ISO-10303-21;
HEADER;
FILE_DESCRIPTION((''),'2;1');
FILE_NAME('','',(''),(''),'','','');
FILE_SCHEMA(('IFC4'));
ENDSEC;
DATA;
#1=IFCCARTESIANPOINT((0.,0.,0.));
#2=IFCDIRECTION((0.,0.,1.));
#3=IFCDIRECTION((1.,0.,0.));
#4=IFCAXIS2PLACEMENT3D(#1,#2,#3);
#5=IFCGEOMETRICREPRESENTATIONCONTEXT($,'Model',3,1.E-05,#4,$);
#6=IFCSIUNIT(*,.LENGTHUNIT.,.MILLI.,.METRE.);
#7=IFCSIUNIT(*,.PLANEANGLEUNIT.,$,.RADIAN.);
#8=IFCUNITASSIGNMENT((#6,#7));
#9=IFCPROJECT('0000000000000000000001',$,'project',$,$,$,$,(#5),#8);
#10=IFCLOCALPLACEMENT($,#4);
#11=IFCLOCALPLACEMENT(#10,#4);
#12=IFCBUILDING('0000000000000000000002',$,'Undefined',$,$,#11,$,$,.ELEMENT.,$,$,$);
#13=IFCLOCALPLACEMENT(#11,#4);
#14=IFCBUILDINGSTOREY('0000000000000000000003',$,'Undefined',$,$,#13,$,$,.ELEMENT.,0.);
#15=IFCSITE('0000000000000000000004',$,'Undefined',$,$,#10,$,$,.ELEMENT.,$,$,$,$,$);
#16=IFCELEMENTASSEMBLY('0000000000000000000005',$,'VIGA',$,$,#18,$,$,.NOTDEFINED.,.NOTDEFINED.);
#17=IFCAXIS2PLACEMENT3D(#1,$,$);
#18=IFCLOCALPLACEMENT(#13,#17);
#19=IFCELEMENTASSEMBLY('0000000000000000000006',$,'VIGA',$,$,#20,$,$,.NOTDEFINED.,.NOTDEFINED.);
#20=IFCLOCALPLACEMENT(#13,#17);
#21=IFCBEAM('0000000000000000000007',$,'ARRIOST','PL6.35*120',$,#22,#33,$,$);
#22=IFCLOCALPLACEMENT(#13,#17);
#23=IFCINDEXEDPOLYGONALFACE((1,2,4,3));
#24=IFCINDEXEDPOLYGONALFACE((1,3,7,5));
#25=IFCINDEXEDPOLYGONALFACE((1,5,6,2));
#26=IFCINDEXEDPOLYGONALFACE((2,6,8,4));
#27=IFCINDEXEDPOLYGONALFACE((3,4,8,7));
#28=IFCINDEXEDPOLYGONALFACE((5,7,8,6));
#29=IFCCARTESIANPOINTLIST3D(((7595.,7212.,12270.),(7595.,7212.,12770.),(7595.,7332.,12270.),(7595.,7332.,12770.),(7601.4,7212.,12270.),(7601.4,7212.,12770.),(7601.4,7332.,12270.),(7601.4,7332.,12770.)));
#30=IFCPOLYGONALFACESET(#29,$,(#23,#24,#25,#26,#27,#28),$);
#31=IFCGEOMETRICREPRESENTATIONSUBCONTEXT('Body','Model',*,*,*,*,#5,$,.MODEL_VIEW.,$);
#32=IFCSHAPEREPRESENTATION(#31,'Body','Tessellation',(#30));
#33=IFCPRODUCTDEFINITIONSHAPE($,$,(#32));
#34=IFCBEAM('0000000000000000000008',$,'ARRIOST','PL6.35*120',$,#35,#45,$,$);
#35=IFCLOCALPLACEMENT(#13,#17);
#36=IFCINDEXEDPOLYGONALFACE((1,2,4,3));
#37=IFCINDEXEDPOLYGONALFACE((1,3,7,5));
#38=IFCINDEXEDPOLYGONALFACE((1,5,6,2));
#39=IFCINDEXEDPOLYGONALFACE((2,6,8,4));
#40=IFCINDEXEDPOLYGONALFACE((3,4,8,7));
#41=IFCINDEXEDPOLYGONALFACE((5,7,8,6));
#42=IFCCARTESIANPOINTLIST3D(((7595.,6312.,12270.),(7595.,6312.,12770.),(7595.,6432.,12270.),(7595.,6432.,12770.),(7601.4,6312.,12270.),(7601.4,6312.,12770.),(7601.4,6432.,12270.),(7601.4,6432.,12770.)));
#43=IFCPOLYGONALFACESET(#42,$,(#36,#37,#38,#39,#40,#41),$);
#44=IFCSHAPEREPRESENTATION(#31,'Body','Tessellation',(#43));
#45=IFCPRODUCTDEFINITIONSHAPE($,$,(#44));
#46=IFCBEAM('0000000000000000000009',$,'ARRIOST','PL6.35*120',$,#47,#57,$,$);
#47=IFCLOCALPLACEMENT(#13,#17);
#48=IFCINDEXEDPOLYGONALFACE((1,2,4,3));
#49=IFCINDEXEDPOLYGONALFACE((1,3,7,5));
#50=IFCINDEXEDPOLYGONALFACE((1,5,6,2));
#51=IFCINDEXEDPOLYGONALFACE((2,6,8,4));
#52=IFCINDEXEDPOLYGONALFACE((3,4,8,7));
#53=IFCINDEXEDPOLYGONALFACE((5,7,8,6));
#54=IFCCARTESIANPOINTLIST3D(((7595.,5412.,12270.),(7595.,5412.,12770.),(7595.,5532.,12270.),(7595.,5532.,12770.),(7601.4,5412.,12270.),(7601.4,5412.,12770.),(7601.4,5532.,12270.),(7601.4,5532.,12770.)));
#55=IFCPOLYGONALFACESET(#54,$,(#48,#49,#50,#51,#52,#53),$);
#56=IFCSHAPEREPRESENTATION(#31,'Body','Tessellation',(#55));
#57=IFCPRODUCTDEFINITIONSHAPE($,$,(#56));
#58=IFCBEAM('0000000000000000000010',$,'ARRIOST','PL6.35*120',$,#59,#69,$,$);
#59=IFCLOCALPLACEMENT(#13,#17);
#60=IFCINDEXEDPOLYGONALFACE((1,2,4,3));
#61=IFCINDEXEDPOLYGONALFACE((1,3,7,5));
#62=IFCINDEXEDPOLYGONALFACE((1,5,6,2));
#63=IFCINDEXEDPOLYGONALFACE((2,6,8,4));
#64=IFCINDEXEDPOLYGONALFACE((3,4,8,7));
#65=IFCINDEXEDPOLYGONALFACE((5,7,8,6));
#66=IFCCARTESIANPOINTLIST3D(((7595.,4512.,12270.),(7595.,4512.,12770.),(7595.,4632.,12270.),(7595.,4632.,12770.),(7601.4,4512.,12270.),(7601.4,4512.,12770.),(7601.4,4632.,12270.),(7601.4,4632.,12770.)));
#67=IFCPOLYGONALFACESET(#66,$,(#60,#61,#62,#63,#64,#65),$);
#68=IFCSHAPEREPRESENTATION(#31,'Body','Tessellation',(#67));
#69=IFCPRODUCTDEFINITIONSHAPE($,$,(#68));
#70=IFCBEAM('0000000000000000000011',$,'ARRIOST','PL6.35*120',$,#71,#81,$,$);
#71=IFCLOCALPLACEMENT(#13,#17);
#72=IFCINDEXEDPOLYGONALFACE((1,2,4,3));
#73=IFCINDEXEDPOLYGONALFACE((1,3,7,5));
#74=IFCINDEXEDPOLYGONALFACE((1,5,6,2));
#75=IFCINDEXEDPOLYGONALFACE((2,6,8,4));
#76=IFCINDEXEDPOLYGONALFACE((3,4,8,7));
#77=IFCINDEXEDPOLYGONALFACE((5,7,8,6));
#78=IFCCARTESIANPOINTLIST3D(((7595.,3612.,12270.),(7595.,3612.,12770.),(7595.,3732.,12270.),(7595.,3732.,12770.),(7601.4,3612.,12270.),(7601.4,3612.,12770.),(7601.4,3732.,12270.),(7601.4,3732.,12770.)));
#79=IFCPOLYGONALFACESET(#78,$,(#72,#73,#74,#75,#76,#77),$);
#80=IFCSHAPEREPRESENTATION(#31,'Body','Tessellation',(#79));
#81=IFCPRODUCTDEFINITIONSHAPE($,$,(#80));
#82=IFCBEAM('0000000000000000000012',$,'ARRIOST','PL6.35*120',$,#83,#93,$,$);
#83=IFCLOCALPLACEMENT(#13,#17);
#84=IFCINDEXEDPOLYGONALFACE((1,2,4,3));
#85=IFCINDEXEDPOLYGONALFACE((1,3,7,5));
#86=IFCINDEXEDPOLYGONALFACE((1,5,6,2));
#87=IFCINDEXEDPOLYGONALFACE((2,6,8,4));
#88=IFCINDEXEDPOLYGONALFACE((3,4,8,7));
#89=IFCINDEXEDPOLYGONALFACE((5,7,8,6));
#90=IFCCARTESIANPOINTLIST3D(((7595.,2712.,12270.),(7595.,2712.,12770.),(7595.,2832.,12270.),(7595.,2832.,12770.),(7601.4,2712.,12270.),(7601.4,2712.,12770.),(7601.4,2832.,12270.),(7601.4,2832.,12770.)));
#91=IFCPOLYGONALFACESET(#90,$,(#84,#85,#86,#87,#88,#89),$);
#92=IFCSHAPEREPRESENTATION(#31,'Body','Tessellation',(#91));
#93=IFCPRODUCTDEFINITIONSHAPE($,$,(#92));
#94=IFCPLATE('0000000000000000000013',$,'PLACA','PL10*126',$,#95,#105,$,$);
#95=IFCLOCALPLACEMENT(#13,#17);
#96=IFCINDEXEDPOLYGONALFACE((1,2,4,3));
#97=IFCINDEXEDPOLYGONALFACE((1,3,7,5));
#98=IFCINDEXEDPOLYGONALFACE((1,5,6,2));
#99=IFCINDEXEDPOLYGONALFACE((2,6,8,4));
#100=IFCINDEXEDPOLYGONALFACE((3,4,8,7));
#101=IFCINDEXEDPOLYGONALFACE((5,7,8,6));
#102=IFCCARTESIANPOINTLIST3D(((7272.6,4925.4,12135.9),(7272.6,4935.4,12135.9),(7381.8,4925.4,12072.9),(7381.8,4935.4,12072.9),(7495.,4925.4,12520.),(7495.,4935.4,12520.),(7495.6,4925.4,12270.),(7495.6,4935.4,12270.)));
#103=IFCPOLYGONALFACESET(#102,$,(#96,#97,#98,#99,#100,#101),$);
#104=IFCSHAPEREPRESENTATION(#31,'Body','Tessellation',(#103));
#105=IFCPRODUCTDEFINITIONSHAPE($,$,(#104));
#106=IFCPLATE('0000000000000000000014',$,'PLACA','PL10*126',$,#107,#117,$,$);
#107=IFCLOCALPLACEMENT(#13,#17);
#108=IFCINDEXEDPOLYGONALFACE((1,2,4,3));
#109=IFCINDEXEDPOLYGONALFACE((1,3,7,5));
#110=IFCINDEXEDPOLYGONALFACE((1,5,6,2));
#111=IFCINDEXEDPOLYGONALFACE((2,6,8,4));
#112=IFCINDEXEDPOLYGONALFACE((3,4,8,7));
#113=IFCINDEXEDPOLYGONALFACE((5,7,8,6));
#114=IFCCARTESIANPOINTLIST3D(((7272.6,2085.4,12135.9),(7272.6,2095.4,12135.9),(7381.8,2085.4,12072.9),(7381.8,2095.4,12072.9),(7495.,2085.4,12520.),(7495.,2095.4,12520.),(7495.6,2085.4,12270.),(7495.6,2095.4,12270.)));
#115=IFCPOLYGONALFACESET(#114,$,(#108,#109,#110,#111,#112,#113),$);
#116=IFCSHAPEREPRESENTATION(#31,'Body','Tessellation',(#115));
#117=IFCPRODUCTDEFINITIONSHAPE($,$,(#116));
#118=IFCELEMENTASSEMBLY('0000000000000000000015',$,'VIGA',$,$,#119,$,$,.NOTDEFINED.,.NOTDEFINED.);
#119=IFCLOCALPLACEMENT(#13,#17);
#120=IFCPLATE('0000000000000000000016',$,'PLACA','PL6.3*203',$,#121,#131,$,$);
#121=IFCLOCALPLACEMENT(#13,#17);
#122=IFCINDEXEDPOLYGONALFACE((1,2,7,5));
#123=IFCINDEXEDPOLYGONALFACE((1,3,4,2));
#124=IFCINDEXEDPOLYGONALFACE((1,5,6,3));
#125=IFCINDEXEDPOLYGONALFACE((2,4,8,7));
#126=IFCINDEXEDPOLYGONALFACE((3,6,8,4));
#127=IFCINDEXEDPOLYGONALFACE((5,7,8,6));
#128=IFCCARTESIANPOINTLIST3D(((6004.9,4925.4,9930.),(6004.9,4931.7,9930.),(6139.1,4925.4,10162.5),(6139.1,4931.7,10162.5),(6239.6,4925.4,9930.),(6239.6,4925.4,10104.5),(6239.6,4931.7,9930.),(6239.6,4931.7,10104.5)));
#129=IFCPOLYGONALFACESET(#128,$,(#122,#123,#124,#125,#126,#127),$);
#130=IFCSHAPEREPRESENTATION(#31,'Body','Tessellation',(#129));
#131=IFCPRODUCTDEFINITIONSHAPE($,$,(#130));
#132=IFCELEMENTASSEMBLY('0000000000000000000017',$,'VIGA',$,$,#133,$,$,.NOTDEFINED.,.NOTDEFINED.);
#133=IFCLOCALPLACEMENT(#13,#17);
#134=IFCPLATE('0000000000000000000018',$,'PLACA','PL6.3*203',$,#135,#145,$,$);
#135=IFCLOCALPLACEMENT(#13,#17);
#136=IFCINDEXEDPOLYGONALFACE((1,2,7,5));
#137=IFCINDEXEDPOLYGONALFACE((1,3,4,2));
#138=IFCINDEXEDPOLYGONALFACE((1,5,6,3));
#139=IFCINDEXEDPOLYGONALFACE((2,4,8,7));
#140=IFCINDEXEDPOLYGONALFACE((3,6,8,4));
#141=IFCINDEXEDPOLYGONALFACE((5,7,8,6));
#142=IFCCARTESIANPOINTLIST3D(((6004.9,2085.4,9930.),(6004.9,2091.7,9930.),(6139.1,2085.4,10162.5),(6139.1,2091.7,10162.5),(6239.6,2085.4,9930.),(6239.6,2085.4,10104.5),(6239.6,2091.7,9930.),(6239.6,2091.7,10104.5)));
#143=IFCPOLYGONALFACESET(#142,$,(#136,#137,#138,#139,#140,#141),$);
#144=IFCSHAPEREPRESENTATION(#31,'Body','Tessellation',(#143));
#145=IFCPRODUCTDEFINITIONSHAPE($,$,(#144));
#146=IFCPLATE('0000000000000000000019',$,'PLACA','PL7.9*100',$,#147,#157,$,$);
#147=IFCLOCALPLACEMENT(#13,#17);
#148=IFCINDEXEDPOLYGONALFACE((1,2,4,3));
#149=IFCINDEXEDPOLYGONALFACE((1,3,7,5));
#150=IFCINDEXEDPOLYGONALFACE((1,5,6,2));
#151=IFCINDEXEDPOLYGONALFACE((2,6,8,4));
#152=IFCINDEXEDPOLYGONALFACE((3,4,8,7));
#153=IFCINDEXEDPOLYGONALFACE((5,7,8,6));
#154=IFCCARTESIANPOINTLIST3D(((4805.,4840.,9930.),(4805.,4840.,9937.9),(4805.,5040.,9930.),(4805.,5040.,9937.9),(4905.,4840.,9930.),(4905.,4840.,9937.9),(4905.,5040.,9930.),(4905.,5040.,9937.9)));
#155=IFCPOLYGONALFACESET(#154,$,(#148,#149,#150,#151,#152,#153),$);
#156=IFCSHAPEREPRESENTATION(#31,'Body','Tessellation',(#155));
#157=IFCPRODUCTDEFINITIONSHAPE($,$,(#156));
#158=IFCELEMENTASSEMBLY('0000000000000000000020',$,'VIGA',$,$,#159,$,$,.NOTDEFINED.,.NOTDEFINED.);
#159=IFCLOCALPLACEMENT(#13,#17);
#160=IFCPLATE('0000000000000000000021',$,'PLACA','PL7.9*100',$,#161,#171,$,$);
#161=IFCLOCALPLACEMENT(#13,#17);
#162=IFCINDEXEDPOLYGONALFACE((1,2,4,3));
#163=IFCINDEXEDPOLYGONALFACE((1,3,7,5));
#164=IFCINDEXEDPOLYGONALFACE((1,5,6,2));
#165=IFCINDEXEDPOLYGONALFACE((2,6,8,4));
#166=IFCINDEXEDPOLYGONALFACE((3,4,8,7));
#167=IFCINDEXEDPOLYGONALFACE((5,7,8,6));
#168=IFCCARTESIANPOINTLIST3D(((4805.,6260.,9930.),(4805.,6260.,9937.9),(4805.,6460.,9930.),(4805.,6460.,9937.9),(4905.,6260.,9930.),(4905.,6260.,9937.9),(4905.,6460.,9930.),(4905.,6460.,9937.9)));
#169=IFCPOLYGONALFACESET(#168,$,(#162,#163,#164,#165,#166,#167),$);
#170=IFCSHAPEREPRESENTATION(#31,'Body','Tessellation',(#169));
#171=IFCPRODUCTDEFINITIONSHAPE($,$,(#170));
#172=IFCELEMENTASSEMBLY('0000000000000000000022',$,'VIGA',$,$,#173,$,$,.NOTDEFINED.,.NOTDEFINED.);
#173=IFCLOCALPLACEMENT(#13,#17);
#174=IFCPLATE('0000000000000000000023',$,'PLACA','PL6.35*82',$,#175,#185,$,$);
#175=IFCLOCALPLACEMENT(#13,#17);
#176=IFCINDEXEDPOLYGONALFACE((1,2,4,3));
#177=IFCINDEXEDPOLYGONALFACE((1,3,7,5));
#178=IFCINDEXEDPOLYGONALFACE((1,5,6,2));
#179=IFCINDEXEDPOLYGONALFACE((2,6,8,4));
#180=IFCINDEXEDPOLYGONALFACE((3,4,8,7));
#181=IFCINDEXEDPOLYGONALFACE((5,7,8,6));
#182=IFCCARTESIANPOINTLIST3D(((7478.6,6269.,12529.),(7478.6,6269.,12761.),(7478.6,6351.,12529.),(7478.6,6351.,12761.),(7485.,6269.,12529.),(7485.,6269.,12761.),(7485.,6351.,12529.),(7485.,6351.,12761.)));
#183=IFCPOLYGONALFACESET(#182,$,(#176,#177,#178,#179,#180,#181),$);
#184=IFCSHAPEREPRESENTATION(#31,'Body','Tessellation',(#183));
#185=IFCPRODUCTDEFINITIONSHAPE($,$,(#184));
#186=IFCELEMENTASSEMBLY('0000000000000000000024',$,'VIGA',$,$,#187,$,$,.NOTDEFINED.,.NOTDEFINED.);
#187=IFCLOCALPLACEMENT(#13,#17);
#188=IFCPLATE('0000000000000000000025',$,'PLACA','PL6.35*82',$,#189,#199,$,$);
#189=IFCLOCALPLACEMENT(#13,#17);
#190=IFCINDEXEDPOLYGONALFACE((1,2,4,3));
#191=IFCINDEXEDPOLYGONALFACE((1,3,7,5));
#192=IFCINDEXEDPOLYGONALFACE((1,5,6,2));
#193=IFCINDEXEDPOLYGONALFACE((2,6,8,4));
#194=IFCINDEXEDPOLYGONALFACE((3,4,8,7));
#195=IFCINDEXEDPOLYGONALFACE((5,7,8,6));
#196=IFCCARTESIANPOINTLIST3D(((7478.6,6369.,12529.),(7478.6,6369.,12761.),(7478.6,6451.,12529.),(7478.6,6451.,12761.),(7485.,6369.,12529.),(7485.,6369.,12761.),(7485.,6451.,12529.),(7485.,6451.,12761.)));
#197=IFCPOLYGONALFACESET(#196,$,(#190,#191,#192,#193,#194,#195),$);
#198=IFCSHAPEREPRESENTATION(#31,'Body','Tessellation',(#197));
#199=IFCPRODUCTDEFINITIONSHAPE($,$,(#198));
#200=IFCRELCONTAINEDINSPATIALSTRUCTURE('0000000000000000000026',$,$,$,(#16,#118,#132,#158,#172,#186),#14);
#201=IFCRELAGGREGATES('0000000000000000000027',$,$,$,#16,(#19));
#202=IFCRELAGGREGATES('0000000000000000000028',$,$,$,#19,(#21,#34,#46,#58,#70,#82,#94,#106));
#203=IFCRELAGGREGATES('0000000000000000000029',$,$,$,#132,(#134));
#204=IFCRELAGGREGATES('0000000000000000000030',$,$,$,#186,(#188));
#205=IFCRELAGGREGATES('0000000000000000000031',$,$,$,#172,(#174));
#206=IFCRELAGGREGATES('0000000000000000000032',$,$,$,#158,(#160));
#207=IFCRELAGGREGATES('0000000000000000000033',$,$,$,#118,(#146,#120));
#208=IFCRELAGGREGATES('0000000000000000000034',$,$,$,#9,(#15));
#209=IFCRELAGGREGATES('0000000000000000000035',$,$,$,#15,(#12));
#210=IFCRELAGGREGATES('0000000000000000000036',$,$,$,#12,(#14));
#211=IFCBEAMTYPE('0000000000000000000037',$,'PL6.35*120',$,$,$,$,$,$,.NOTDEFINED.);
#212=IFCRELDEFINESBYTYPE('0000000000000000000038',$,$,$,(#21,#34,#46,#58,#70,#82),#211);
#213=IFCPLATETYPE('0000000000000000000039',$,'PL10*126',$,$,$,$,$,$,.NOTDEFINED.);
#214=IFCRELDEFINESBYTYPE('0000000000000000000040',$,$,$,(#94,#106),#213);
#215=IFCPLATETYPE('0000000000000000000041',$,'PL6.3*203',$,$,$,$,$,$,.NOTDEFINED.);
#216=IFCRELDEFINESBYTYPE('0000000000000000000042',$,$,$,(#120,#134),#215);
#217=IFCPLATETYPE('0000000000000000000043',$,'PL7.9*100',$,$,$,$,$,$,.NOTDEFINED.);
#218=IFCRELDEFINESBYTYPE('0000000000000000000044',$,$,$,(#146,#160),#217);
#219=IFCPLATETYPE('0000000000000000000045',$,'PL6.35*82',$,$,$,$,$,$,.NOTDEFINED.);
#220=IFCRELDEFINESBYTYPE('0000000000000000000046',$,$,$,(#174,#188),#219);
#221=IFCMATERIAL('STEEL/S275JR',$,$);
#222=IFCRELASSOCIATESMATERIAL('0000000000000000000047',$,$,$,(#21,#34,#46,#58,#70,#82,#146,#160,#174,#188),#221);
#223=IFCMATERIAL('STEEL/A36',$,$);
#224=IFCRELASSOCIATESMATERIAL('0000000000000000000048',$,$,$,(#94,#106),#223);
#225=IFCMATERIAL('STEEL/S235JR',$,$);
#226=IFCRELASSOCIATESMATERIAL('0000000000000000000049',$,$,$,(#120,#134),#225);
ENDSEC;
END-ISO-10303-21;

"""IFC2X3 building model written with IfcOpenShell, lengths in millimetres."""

from ifc_helpers import new_model, si_unit, frame, origin_with_axes, origin_2d_with_axis, place, context, subcontext, project, spatial, polyline, rectangle, outline, extrude, material, type_object, element, aggregate, save


model = new_model("IFC2X3")

# Units and contexts
model_context = context("Model", 3, precision=1e-05, world=origin_with_axes())
body_context = subcontext(model_context, "Body", "Model", "MODEL_VIEW")
ifc_project = project(units=[si_unit("LENGTHUNIT", "METRE", prefix="MILLI"), si_unit("PLANEANGLEUNIT", "RADIAN")], contexts=[model_context])

# Site, building, storey
site_placement = place(None, origin_with_axes())
site = spatial("IfcSite", under=ifc_project, at=site_placement, Name="Undefined", CompositionType="ELEMENT")
building_placement = place(site_placement, origin_with_axes())
building = spatial("IfcBuilding", under=site, at=building_placement, Name="Undefined", CompositionType="ELEMENT")
storey_placement = place(building_placement, origin_with_axes())
storey = spatial("IfcBuildingStorey", under=building, at=storey_placement, Name="Undefined", CompositionType="ELEMENT", Elevation=0.0)

# Element assemblies, beams, plates
assembly_1_placement = place(storey_placement, origin_with_axes())
assembly_1 = element("IfcElementAssembly", 1, at=assembly_1_placement, inside=storey, Name="VIGA", AssemblyPlace="NOTDEFINED", PredefinedType="NOTDEFINED")
assembly_2_placement = place(assembly_1_placement, origin_with_axes())
assembly_2 = element("IfcElementAssembly", 2, at=assembly_2_placement, Name="VIGA", AssemblyPlace="NOTDEFINED", PredefinedType="NOTDEFINED")
aggregate(assembly_1, [assembly_2])
ifc_material_1 = material(Name="STEEL/S275JR")
beam_type = type_object("IfcBeamType", Name="PL6.35*120", PredefinedType="NOTDEFINED")
beam_1_placement = place(assembly_2_placement, frame((7598.2, 7272.0, 12270.0), z_axis=(0.0, 1.0, 0.0), x_axis=(0.0, 0.0, 1.0)))
beam_1 = element("IfcBeam", 3, at=beam_1_placement, type_object=beam_type, material=ifc_material_1, Name="ARRIOST", Description="PL6.35*120", context=body_context, shape_type="SweptSolid", body=[
    extrude(rectangle(XDim=6.3, YDim=120.0, at=origin_2d_with_axis()), frame((500.0, 0.0, 0.0), z_axis=(-1.0, 0.0, 0.0), x_axis=(0.0, -1.0, 0.0)), (0.0, 0.0, 1.0), 500.0),
])
beam_2_placement = place(assembly_2_placement, frame((7598.2, 6372.0, 12270.0), z_axis=(0.0, 1.0, 0.0), x_axis=(0.0, 0.0, 1.0)))
beam_2 = element("IfcBeam", 4, at=beam_2_placement, type_object=beam_type, material=ifc_material_1, Name="ARRIOST", Description="PL6.35*120", context=body_context, shape_type="SweptSolid", body=[
    extrude(rectangle(XDim=6.3, YDim=120.0, at=origin_2d_with_axis()), frame((500.0, 0.0, 0.0), z_axis=(-1.0, 0.0, 0.0), x_axis=(0.0, -1.0, 0.0)), (0.0, 0.0, 1.0), 500.0),
])
beam_3_placement = place(assembly_2_placement, frame((7598.2, 5472.0, 12270.0), z_axis=(0.0, 1.0, 0.0), x_axis=(0.0, 0.0, 1.0)))
beam_3 = element("IfcBeam", 5, at=beam_3_placement, type_object=beam_type, material=ifc_material_1, Name="ARRIOST", Description="PL6.35*120", context=body_context, shape_type="SweptSolid", body=[
    extrude(rectangle(XDim=6.3, YDim=120.0, at=origin_2d_with_axis()), frame((500.0, 0.0, 0.0), z_axis=(-1.0, 0.0, 0.0), x_axis=(0.0, -1.0, 0.0)), (0.0, 0.0, 1.0), 500.0),
])
beam_4_placement = place(assembly_2_placement, frame((7598.2, 4572.0, 12270.0), z_axis=(0.0, 1.0, 0.0), x_axis=(0.0, 0.0, 1.0)))
beam_4 = element("IfcBeam", 6, at=beam_4_placement, type_object=beam_type, material=ifc_material_1, Name="ARRIOST", Description="PL6.35*120", context=body_context, shape_type="SweptSolid", body=[
    extrude(rectangle(XDim=6.3, YDim=120.0, at=origin_2d_with_axis()), frame((500.0, 0.0, 0.0), z_axis=(-1.0, 0.0, 0.0), x_axis=(0.0, -1.0, 0.0)), (0.0, 0.0, 1.0), 500.0),
])
beam_5_placement = place(assembly_2_placement, frame((7598.2, 3672.0, 12270.0), z_axis=(0.0, 1.0, 0.0), x_axis=(0.0, 0.0, 1.0)))
beam_5 = element("IfcBeam", 7, at=beam_5_placement, type_object=beam_type, material=ifc_material_1, Name="ARRIOST", Description="PL6.35*120", context=body_context, shape_type="SweptSolid", body=[
    extrude(rectangle(XDim=6.3, YDim=120.0, at=origin_2d_with_axis()), frame((500.0, 0.0, 0.0), z_axis=(-1.0, 0.0, 0.0), x_axis=(0.0, -1.0, 0.0)), (0.0, 0.0, 1.0), 500.0),
])
beam_6_placement = place(assembly_2_placement, frame((7598.2, 2772.0, 12270.0), z_axis=(0.0, 1.0, 0.0), x_axis=(0.0, 0.0, 1.0)))
beam_6 = element("IfcBeam", 8, at=beam_6_placement, type_object=beam_type, material=ifc_material_1, Name="ARRIOST", Description="PL6.35*120", context=body_context, shape_type="SweptSolid", body=[
    extrude(rectangle(XDim=6.3, YDim=120.0, at=origin_2d_with_axis()), frame((500.0, 0.0, 0.0), z_axis=(-1.0, 0.0, 0.0), x_axis=(0.0, -1.0, 0.0)), (0.0, 0.0, 1.0), 500.0),
])
ifc_material_2 = material(Name="STEEL/A36")
plate_type_1 = type_object("IfcPlateType", Name="PL10*126", PredefinedType="NOTDEFINED")
plate_1_placement = place(assembly_2_placement, frame((7495.0, 4930.4, 12520.0), z_axis=(0.0, -1.0, 0.0), x_axis=(-0.500975, 0.0, -0.865462)))
plate_1 = element("IfcPlate", 9, at=plate_1_placement, type_object=plate_type_1, material=ifc_material_2, Name="PLACA", Description="PL10*126", context=body_context, shape_type="SweptSolid", body=[
    extrude(outline(polyline([(0.0, 0.0), (443.9, 0.0), (443.7, 126.0), (216.1, 125.7), (0.0, 0.0)])), frame((0.0, 0.0, -5.0), z_axis=(0.0, 0.0, 1.0), x_axis=(1.0, 0.0, 0.0)), (0.0, 0.0, 1.0), 10.0),
])
plate_2_placement = place(assembly_2_placement, frame((7495.0, 2090.4, 12520.0), z_axis=(0.0, -1.0, 0.0), x_axis=(-0.500975, 0.0, -0.865462)))
plate_2 = element("IfcPlate", 10, at=plate_2_placement, type_object=plate_type_1, material=ifc_material_2, Name="PLACA", Description="PL10*126", context=body_context, shape_type="SweptSolid", body=[
    extrude(outline(polyline([(0.0, 0.0), (443.9, 0.0), (443.7, 126.0), (216.1, 125.7), (0.0, 0.0)])), frame((0.0, 0.0, -5.0), z_axis=(0.0, 0.0, 1.0), x_axis=(1.0, 0.0, 0.0)), (0.0, 0.0, 1.0), 10.0),
])
aggregate(assembly_2, [beam_1, beam_2, beam_3, beam_4, beam_5, beam_6, plate_1, plate_2])

# Element assemblies, plates
assembly_3_placement = place(storey_placement, origin_with_axes())
assembly_3 = element("IfcElementAssembly", 11, at=assembly_3_placement, inside=storey, Name="VIGA", AssemblyPlace="NOTDEFINED", PredefinedType="NOTDEFINED")
ifc_material_3 = material(Name="STEEL/S235JR")
plate_type_2 = type_object("IfcPlateType", Name="PL6.3*203", PredefinedType="NOTDEFINED")
plate_3_placement = place(assembly_3_placement, frame((6239.6, 4928.6, 9930.0), z_axis=(0.0, 1.0, 0.0), x_axis=(-1.0, 0.0, 0.0)))
plate_3 = element("IfcPlate", 12, at=plate_3_placement, type_object=plate_type_2, material=ifc_material_3, Name="PLACA", Description="PL6.3*203", context=body_context, shape_type="SweptSolid", body=[
    extrude(outline(polyline([(0.0, 0.0), (234.7, 0.0), (100.5, 232.5), (0.0, 174.5), (0.0, 0.0)])), frame((0.0, 0.0, -3.1), z_axis=(0.0, 0.0, 1.0), x_axis=(1.0, 0.0, 0.0)), (0.0, 0.0, 1.0), 6.3),
])
assembly_4_placement = place(storey_placement, origin_with_axes())
assembly_4 = element("IfcElementAssembly", 13, at=assembly_4_placement, inside=storey, Name="VIGA", AssemblyPlace="NOTDEFINED", PredefinedType="NOTDEFINED")
plate_4_placement = place(assembly_4_placement, frame((6239.6, 2088.6, 9930.0), z_axis=(0.0, 1.0, 0.0), x_axis=(-1.0, 0.0, 0.0)))
plate_4 = element("IfcPlate", 14, at=plate_4_placement, type_object=plate_type_2, material=ifc_material_3, Name="PLACA", Description="PL6.3*203", context=body_context, shape_type="SweptSolid", body=[
    extrude(outline(polyline([(0.0, 0.0), (234.7, 0.0), (100.5, 232.5), (0.0, 174.5), (0.0, 0.0)])), frame((0.0, 0.0, -3.1), z_axis=(0.0, 0.0, 1.0), x_axis=(1.0, 0.0, 0.0)), (0.0, 0.0, 1.0), 6.3),
])
aggregate(assembly_4, [plate_4])

# Plate
plate_type_3 = type_object("IfcPlateType", Name="PL7.9*100", PredefinedType="NOTDEFINED")
plate_5_placement = place(assembly_3_placement, frame((4905.0, 5040.0, 9934.0), z_axis=(0.0, 0.0, 1.0), x_axis=(-1.0, 0.0, 0.0)))
plate_5 = element("IfcPlate", 15, at=plate_5_placement, type_object=plate_type_3, material=ifc_material_1, Name="PLACA", Description="PL7.9*100", context=body_context, shape_type="SweptSolid", body=[
    extrude(outline(polyline([(0.0, 0.0), (100.0, 0.0), (100.0, 200.0), (0.0, 200.0), (0.0, 0.0)])), frame((0.0, 0.0, -4.0), z_axis=(0.0, 0.0, 1.0), x_axis=(1.0, 0.0, 0.0)), (0.0, 0.0, 1.0), 7.9),
])

# Element assemblies, plates
assembly_5_placement = place(storey_placement, origin_with_axes())
assembly_5 = element("IfcElementAssembly", 16, at=assembly_5_placement, inside=storey, Name="VIGA", AssemblyPlace="NOTDEFINED", PredefinedType="NOTDEFINED")
plate_6_placement = place(assembly_5_placement, frame((4905.0, 6460.0, 9934.0), z_axis=(0.0, 0.0, 1.0), x_axis=(-1.0, 0.0, 0.0)))
plate_6 = element("IfcPlate", 17, at=plate_6_placement, type_object=plate_type_3, material=ifc_material_1, Name="PLACA", Description="PL7.9*100", context=body_context, shape_type="SweptSolid", body=[
    extrude(outline(polyline([(0.0, 0.0), (100.0, 0.0), (100.0, 200.0), (0.0, 200.0), (0.0, 0.0)])), frame((0.0, 0.0, -4.0), z_axis=(0.0, 0.0, 1.0), x_axis=(1.0, 0.0, 0.0)), (0.0, 0.0, 1.0), 7.9),
])
assembly_6_placement = place(storey_placement, origin_with_axes())
assembly_6 = element("IfcElementAssembly", 18, at=assembly_6_placement, inside=storey, Name="VIGA", AssemblyPlace="NOTDEFINED", PredefinedType="NOTDEFINED")
plate_type_4 = type_object("IfcPlateType", Name="PL6.35*82", PredefinedType="NOTDEFINED")
plate_7_placement = place(assembly_6_placement, frame((7481.8, 6269.0, 12761.0), z_axis=(-1.0, 0.0, 0.0), x_axis=(0.0, 1.0, 0.0)))
plate_7 = element("IfcPlate", 19, at=plate_7_placement, type_object=plate_type_4, material=ifc_material_1, Name="PLACA", Description="PL6.35*82", context=body_context, shape_type="SweptSolid", body=[
    extrude(outline(polyline([(0.0, 0.0), (82.0, 0.0), (82.0, 232.0), (0.0, 232.0), (0.0, 0.0)])), frame((0.0, 0.0, -3.2), z_axis=(0.0, 0.0, 1.0), x_axis=(1.0, 0.0, 0.0)), (0.0, 0.0, 1.0), 6.4),
])
assembly_7_placement = place(storey_placement, origin_with_axes())
assembly_7 = element("IfcElementAssembly", 20, at=assembly_7_placement, inside=storey, Name="VIGA", AssemblyPlace="NOTDEFINED", PredefinedType="NOTDEFINED")
plate_8_placement = place(assembly_7_placement, frame((7481.8, 6369.0, 12761.0), z_axis=(-1.0, 0.0, 0.0), x_axis=(0.0, 1.0, 0.0)))
plate_8 = element("IfcPlate", 21, at=plate_8_placement, type_object=plate_type_4, material=ifc_material_1, Name="PLACA", Description="PL6.35*82", context=body_context, shape_type="SweptSolid", body=[
    extrude(outline(polyline([(0.0, 0.0), (82.0, 0.0), (82.0, 232.0), (0.0, 232.0), (0.0, 0.0)])), frame((0.0, 0.0, -3.2), z_axis=(0.0, 0.0, 1.0), x_axis=(1.0, 0.0, 0.0)), (0.0, 0.0, 1.0), 6.4),
])
aggregate(assembly_7, [plate_8])

aggregate(assembly_6, [plate_7])

aggregate(assembly_5, [plate_6])

aggregate(assembly_3, [plate_5, plate_3])

save(model, "model.ifc")
